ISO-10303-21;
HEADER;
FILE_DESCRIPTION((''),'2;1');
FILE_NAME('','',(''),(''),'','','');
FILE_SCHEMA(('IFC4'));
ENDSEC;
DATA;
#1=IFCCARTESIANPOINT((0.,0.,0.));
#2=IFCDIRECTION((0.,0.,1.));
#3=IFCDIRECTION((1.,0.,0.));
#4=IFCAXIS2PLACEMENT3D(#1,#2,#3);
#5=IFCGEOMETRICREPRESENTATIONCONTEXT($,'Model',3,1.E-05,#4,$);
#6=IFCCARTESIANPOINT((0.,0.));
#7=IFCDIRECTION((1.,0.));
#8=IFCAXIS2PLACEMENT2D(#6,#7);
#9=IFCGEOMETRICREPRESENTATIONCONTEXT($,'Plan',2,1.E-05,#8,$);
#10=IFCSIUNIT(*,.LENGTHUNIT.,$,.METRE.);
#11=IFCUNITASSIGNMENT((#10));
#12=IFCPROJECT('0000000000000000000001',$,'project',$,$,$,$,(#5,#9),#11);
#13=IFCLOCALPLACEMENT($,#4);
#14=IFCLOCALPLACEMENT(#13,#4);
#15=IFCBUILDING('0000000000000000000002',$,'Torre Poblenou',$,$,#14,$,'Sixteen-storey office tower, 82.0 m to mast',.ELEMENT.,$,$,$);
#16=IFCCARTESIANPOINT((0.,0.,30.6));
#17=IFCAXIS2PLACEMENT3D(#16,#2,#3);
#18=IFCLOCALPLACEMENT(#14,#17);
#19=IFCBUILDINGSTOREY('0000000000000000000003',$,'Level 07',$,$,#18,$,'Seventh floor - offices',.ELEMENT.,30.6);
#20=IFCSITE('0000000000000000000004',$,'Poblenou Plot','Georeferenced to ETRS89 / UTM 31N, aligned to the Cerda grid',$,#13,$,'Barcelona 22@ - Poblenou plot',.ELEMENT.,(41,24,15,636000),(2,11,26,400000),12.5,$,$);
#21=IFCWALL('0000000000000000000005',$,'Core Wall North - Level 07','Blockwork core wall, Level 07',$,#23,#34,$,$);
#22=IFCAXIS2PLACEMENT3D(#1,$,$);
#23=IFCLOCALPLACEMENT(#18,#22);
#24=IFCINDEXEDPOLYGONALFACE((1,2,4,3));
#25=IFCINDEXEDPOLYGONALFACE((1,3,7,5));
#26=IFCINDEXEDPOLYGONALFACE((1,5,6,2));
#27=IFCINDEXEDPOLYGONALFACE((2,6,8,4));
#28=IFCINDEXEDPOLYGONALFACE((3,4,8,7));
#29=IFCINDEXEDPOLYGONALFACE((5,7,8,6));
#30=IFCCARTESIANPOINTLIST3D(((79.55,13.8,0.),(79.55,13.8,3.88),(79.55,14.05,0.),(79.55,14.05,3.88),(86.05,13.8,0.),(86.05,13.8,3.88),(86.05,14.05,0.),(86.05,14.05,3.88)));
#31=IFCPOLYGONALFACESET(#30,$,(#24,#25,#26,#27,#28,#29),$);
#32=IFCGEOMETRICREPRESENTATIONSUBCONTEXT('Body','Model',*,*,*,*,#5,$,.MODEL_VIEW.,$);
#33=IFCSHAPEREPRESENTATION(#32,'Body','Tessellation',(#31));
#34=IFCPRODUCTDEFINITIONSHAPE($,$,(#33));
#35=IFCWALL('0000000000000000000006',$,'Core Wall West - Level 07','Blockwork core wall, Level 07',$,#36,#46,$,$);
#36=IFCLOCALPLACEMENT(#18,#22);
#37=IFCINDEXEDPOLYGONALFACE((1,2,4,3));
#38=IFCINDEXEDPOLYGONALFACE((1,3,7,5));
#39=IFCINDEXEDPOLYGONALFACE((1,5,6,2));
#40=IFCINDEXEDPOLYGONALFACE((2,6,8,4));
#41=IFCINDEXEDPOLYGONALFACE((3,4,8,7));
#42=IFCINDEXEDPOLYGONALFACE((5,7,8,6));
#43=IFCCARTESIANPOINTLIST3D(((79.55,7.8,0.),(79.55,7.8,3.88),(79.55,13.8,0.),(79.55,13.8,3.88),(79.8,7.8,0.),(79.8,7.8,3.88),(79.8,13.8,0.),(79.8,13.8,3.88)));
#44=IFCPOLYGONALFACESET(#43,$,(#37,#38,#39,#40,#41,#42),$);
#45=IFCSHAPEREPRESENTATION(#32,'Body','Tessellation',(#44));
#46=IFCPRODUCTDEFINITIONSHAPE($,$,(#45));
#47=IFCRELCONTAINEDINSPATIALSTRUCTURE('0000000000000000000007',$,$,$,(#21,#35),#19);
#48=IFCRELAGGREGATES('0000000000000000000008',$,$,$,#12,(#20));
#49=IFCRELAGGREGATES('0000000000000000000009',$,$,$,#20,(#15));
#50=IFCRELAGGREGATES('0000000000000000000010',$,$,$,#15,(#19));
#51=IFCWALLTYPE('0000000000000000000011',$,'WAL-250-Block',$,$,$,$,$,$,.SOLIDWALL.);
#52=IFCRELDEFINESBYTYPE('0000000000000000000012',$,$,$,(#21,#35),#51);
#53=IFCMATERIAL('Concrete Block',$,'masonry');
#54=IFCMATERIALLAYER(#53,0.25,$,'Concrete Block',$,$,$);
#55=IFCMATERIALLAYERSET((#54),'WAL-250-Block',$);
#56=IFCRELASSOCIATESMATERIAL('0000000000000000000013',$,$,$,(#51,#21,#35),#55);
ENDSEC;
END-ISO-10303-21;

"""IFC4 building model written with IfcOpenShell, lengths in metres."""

from ifc_helpers import new_model, si_unit, frame, origin_with_axes, origin_2d_with_axis, place, context, subcontext, project, spatial, line, indexed_curve, outline, extrude, material, layer, layer_set, layer_usage, type_object, element, save


model = new_model("IFC4")

# Units and contexts
model_context = context("Model", 3, precision=1e-05, world=origin_with_axes())
plan_context = context("Plan", 2, precision=1e-05, world=origin_2d_with_axis())
body_context = subcontext(model_context, "Body", "Model", "MODEL_VIEW")
ifc_project = project(units=[si_unit("LENGTHUNIT", "METRE")], contexts=[model_context, plan_context])

# Site, building, storey
site_placement = place(None, origin_with_axes())
site = spatial("IfcSite", under=ifc_project, at=site_placement, Name="Poblenou Plot", Description="Georeferenced to ETRS89 / UTM 31N, aligned to the Cerda grid", LongName="Barcelona 22@ - Poblenou plot", CompositionType="ELEMENT", RefLatitude=(41, 24, 15, 636000), RefLongitude=(2, 11, 26, 400000), RefElevation=12.5)
building_placement = place(site_placement, origin_with_axes())
building = spatial("IfcBuilding", under=site, at=building_placement, Name="Torre Poblenou", LongName="Sixteen-storey office tower, 82.0 m to mast", CompositionType="ELEMENT")
storey_placement = place(building_placement, frame((0.0, 0.0, 30.6), z_axis=(0.0, 0.0, 1.0), x_axis=(1.0, 0.0, 0.0)))
storey = spatial("IfcBuildingStorey", under=building, at=storey_placement, Name="Level 07", LongName="Seventh floor - offices", CompositionType="ELEMENT", Elevation=30.6)

# Walls
ifc_material_1 = material(Name="Concrete Block", Category="masonry")
ifc_layer_1 = layer(ifc_material_1, 0.25, Name="Concrete Block")
ifc_layer_set_1 = layer_set([ifc_layer_1], Name="WAL-250-Block")
ifc_layer_usage_1 = layer_usage(ifc_layer_set_1, "AXIS2", "POSITIVE", 0.0)
wall_type = type_object("IfcWallType", Name="WAL-250-Block", PredefinedType="SOLIDWALL", material=ifc_layer_set_1)
wall_1_placement = place(storey_placement, frame((79.55, 13.8, 0.0), z_axis=(0.0, 0.0, 1.0), x_axis=(1.0, 0.0, 0.0)))
element("IfcWall", 1, at=wall_1_placement, inside=storey, type_object=wall_type, material=ifc_layer_usage_1, Name="Core Wall North - Level 07", Description="Blockwork core wall, Level 07", context=body_context, shape_type="SweptSolid", body=[
    extrude(outline(indexed_curve([(0.0, 0.0), (6.5, 0.0), (6.5, 0.25), (0.0, 0.25)], segments=[line(1, 2, 3, 4, 1)])), origin_with_axes(), (0.0, 0.0, 1.0), 3.88),
])
ifc_layer_usage_2 = layer_usage(ifc_layer_set_1, "AXIS2", "POSITIVE", 0.0)
wall_2_placement = place(storey_placement, frame((79.8, 7.8, 0.0), z_axis=(0.0, 0.0, 1.0), x_axis=(0.0, 1.0, 0.0)))
element("IfcWall", 2, at=wall_2_placement, inside=storey, type_object=wall_type, material=ifc_layer_usage_2, Name="Core Wall West - Level 07", Description="Blockwork core wall, Level 07", context=body_context, shape_type="SweptSolid", body=[
    extrude(outline(indexed_curve([(0.0, 0.0), (6.0, 0.0), (6.0, 0.25), (0.0, 0.25)], segments=[line(1, 2, 3, 4, 1)])), origin_with_axes(), (0.0, 0.0, 1.0), 3.88),
])

save(model, "model.ifc")
